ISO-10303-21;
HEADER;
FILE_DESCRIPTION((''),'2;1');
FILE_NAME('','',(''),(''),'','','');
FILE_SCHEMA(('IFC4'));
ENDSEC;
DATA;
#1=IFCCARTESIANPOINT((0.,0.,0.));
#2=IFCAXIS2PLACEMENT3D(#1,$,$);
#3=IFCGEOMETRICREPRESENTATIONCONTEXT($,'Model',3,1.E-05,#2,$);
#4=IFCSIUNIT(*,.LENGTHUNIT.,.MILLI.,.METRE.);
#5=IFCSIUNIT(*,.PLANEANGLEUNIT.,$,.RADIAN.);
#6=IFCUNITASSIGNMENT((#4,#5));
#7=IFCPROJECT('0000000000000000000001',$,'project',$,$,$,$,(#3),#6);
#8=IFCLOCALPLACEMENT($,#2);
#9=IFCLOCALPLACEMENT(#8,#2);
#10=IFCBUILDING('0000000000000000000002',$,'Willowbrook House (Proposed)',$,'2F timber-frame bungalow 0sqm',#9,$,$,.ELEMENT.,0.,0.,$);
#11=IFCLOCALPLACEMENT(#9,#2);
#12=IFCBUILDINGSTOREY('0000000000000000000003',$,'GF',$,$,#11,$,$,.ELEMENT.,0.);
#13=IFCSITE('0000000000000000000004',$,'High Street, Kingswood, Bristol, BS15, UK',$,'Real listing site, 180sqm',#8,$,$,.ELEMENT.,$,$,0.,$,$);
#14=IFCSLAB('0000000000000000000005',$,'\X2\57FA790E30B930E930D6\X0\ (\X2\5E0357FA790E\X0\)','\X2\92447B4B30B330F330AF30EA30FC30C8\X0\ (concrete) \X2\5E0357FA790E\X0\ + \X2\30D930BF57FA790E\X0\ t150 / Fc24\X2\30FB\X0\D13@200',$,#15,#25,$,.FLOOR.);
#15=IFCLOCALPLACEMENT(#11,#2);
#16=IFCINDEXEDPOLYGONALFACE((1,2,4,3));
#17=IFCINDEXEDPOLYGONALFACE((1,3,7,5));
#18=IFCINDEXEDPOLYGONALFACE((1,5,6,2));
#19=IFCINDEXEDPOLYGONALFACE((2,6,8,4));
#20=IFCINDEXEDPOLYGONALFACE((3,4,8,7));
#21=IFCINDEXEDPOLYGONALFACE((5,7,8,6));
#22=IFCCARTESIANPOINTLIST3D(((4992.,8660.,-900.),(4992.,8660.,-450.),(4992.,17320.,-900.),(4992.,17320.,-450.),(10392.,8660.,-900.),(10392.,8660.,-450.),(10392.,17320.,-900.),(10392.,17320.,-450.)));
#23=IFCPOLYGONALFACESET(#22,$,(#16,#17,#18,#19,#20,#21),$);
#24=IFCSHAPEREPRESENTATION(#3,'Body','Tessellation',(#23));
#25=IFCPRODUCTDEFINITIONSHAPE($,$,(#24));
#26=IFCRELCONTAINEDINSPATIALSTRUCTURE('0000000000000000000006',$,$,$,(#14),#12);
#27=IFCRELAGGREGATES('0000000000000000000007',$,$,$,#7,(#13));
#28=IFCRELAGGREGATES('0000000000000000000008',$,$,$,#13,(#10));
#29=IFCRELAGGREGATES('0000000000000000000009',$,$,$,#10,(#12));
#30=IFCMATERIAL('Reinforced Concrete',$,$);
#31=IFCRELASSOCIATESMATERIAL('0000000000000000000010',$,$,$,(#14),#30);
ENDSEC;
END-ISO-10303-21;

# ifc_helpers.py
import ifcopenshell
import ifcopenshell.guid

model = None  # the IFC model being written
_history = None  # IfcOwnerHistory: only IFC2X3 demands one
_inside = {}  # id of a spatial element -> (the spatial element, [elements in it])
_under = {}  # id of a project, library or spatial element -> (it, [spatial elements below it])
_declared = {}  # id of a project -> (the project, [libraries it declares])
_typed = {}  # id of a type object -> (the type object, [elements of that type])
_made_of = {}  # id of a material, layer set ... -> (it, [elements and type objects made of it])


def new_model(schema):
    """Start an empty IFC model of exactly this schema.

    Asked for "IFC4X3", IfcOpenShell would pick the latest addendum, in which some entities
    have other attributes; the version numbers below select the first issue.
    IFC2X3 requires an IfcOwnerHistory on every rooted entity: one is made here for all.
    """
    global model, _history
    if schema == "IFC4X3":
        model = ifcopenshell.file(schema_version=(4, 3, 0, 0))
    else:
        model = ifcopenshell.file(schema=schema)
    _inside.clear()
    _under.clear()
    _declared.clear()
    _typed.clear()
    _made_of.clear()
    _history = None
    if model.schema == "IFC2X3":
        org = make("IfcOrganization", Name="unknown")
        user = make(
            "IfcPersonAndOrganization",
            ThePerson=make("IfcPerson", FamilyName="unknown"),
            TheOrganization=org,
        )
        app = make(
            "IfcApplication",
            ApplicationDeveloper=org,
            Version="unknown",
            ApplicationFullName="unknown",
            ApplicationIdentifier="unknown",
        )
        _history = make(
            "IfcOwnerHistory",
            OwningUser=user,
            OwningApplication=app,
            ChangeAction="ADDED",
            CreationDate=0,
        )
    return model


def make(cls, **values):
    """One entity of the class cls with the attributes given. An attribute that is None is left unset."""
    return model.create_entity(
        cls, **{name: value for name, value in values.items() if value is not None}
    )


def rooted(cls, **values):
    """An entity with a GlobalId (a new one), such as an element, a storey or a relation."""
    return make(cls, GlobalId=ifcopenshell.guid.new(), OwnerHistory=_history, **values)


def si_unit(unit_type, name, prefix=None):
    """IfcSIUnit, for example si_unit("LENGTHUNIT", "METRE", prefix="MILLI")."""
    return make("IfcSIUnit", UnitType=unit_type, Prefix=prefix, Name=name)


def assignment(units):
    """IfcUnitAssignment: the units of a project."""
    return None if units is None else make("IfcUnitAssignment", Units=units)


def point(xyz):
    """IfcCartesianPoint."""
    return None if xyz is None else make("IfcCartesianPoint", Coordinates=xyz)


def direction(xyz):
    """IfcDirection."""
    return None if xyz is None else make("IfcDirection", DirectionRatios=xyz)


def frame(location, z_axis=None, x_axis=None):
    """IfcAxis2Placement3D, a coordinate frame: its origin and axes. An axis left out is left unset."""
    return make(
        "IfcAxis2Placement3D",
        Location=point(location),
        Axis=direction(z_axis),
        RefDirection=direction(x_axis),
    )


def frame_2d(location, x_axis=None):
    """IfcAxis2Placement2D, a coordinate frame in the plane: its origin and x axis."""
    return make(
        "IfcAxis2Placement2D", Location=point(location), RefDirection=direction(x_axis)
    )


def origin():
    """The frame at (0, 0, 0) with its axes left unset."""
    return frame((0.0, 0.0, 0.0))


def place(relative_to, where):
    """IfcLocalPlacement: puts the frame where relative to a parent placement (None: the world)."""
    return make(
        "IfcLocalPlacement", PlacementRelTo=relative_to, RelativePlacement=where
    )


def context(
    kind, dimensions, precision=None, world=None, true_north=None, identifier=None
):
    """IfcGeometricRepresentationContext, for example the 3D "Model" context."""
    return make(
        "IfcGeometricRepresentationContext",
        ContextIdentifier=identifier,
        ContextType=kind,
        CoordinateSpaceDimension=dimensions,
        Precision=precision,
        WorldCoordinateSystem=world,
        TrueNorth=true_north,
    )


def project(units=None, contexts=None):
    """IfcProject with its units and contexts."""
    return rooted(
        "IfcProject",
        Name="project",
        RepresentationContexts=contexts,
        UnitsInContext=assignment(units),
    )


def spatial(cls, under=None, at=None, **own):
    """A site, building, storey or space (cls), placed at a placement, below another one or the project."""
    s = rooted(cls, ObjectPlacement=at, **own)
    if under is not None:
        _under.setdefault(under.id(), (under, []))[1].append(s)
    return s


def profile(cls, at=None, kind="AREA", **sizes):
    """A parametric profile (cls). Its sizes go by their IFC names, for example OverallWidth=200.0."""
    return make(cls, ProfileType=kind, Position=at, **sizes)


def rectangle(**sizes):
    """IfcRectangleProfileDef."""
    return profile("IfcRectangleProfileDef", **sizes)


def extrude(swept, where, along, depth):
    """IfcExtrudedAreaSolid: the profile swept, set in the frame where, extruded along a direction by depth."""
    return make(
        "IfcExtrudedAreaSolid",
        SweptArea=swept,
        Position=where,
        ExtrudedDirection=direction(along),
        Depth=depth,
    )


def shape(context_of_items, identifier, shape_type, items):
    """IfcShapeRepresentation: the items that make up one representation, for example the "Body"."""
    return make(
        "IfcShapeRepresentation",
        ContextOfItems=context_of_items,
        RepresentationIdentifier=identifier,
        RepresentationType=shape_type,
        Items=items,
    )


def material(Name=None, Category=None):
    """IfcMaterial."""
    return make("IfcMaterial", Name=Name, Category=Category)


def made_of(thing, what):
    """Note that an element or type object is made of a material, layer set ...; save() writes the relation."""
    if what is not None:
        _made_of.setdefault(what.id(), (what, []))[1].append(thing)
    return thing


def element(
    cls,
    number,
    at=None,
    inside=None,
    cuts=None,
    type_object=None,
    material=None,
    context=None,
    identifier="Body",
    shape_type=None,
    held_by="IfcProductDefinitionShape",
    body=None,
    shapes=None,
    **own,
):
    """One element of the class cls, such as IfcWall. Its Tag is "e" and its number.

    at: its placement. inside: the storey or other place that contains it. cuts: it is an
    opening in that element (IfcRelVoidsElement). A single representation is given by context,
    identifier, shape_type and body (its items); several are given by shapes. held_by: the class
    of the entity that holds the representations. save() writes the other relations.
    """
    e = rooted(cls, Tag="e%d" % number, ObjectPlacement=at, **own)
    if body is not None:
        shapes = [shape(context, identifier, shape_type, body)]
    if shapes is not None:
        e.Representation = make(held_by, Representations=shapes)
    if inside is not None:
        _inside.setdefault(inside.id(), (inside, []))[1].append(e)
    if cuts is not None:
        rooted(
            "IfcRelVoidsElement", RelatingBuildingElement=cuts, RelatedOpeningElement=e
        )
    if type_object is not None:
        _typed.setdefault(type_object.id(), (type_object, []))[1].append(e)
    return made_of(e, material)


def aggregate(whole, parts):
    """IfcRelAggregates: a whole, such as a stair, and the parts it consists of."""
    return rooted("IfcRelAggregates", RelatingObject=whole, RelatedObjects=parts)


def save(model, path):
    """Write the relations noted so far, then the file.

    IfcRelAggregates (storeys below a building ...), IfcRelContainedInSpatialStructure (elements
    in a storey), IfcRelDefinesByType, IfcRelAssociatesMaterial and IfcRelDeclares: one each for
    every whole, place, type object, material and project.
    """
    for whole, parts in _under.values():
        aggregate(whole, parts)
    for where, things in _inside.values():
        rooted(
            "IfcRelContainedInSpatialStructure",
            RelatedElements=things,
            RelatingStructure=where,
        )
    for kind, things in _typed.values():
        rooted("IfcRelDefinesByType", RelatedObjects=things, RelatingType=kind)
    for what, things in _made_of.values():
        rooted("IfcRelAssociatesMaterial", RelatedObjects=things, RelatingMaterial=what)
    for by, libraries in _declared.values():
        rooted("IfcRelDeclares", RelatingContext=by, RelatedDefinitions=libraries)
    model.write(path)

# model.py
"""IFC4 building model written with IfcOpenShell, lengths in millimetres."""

from ifc_helpers import new_model, si_unit, frame, frame_2d, origin, place, context, project, spatial, rectangle, extrude, material, element, save


model = new_model("IFC4")

# Units and contexts
model_context = context("Model", 3, precision=1e-05, world=origin())
ifc_project = project(units=[si_unit("LENGTHUNIT", "METRE", prefix="MILLI"), si_unit("PLANEANGLEUNIT", "RADIAN")], contexts=[model_context])

# Site, building, storey
site_placement = place(None, origin())
site = spatial("IfcSite", under=ifc_project, at=site_placement, Name="High Street, Kingswood, Bristol, BS15, UK", ObjectType="Real listing site, 180sqm", CompositionType="ELEMENT", RefElevation=0.0)
building_placement = place(site_placement, origin())
building = spatial("IfcBuilding", under=site, at=building_placement, Name="Willowbrook House (Proposed)", ObjectType="2F timber-frame bungalow 0sqm", CompositionType="ELEMENT", ElevationOfRefHeight=0.0, ElevationOfTerrain=0.0)
storey_placement = place(building_placement, origin())
storey = spatial("IfcBuildingStorey", under=building, at=storey_placement, Name="GF", CompositionType="ELEMENT", Elevation=0.0)

# Slab
ifc_material_1 = material(Name="Reinforced Concrete")
slab_1_placement = place(storey_placement, frame((2496.0, 4330.0, -450.0)))
element("IfcSlab", 1, at=slab_1_placement, inside=storey, material=ifc_material_1, Name="基礎スラブ (布基礎)", Description="鉄筋コンクリート (concrete) 布基礎 + ベタ基礎 t150 / Fc24・D13@200", PredefinedType="FLOOR", context=model_context, shape_type="SweptSolid", body=[
    extrude(rectangle(XDim=5400.0, YDim=8660.0, at=frame_2d((2700.0, 4330.0))), frame((2496.0, 4330.0, -450.0)), (0.0, 0.0, 1.0), 450.0),
])

save(model, "model.ifc")
